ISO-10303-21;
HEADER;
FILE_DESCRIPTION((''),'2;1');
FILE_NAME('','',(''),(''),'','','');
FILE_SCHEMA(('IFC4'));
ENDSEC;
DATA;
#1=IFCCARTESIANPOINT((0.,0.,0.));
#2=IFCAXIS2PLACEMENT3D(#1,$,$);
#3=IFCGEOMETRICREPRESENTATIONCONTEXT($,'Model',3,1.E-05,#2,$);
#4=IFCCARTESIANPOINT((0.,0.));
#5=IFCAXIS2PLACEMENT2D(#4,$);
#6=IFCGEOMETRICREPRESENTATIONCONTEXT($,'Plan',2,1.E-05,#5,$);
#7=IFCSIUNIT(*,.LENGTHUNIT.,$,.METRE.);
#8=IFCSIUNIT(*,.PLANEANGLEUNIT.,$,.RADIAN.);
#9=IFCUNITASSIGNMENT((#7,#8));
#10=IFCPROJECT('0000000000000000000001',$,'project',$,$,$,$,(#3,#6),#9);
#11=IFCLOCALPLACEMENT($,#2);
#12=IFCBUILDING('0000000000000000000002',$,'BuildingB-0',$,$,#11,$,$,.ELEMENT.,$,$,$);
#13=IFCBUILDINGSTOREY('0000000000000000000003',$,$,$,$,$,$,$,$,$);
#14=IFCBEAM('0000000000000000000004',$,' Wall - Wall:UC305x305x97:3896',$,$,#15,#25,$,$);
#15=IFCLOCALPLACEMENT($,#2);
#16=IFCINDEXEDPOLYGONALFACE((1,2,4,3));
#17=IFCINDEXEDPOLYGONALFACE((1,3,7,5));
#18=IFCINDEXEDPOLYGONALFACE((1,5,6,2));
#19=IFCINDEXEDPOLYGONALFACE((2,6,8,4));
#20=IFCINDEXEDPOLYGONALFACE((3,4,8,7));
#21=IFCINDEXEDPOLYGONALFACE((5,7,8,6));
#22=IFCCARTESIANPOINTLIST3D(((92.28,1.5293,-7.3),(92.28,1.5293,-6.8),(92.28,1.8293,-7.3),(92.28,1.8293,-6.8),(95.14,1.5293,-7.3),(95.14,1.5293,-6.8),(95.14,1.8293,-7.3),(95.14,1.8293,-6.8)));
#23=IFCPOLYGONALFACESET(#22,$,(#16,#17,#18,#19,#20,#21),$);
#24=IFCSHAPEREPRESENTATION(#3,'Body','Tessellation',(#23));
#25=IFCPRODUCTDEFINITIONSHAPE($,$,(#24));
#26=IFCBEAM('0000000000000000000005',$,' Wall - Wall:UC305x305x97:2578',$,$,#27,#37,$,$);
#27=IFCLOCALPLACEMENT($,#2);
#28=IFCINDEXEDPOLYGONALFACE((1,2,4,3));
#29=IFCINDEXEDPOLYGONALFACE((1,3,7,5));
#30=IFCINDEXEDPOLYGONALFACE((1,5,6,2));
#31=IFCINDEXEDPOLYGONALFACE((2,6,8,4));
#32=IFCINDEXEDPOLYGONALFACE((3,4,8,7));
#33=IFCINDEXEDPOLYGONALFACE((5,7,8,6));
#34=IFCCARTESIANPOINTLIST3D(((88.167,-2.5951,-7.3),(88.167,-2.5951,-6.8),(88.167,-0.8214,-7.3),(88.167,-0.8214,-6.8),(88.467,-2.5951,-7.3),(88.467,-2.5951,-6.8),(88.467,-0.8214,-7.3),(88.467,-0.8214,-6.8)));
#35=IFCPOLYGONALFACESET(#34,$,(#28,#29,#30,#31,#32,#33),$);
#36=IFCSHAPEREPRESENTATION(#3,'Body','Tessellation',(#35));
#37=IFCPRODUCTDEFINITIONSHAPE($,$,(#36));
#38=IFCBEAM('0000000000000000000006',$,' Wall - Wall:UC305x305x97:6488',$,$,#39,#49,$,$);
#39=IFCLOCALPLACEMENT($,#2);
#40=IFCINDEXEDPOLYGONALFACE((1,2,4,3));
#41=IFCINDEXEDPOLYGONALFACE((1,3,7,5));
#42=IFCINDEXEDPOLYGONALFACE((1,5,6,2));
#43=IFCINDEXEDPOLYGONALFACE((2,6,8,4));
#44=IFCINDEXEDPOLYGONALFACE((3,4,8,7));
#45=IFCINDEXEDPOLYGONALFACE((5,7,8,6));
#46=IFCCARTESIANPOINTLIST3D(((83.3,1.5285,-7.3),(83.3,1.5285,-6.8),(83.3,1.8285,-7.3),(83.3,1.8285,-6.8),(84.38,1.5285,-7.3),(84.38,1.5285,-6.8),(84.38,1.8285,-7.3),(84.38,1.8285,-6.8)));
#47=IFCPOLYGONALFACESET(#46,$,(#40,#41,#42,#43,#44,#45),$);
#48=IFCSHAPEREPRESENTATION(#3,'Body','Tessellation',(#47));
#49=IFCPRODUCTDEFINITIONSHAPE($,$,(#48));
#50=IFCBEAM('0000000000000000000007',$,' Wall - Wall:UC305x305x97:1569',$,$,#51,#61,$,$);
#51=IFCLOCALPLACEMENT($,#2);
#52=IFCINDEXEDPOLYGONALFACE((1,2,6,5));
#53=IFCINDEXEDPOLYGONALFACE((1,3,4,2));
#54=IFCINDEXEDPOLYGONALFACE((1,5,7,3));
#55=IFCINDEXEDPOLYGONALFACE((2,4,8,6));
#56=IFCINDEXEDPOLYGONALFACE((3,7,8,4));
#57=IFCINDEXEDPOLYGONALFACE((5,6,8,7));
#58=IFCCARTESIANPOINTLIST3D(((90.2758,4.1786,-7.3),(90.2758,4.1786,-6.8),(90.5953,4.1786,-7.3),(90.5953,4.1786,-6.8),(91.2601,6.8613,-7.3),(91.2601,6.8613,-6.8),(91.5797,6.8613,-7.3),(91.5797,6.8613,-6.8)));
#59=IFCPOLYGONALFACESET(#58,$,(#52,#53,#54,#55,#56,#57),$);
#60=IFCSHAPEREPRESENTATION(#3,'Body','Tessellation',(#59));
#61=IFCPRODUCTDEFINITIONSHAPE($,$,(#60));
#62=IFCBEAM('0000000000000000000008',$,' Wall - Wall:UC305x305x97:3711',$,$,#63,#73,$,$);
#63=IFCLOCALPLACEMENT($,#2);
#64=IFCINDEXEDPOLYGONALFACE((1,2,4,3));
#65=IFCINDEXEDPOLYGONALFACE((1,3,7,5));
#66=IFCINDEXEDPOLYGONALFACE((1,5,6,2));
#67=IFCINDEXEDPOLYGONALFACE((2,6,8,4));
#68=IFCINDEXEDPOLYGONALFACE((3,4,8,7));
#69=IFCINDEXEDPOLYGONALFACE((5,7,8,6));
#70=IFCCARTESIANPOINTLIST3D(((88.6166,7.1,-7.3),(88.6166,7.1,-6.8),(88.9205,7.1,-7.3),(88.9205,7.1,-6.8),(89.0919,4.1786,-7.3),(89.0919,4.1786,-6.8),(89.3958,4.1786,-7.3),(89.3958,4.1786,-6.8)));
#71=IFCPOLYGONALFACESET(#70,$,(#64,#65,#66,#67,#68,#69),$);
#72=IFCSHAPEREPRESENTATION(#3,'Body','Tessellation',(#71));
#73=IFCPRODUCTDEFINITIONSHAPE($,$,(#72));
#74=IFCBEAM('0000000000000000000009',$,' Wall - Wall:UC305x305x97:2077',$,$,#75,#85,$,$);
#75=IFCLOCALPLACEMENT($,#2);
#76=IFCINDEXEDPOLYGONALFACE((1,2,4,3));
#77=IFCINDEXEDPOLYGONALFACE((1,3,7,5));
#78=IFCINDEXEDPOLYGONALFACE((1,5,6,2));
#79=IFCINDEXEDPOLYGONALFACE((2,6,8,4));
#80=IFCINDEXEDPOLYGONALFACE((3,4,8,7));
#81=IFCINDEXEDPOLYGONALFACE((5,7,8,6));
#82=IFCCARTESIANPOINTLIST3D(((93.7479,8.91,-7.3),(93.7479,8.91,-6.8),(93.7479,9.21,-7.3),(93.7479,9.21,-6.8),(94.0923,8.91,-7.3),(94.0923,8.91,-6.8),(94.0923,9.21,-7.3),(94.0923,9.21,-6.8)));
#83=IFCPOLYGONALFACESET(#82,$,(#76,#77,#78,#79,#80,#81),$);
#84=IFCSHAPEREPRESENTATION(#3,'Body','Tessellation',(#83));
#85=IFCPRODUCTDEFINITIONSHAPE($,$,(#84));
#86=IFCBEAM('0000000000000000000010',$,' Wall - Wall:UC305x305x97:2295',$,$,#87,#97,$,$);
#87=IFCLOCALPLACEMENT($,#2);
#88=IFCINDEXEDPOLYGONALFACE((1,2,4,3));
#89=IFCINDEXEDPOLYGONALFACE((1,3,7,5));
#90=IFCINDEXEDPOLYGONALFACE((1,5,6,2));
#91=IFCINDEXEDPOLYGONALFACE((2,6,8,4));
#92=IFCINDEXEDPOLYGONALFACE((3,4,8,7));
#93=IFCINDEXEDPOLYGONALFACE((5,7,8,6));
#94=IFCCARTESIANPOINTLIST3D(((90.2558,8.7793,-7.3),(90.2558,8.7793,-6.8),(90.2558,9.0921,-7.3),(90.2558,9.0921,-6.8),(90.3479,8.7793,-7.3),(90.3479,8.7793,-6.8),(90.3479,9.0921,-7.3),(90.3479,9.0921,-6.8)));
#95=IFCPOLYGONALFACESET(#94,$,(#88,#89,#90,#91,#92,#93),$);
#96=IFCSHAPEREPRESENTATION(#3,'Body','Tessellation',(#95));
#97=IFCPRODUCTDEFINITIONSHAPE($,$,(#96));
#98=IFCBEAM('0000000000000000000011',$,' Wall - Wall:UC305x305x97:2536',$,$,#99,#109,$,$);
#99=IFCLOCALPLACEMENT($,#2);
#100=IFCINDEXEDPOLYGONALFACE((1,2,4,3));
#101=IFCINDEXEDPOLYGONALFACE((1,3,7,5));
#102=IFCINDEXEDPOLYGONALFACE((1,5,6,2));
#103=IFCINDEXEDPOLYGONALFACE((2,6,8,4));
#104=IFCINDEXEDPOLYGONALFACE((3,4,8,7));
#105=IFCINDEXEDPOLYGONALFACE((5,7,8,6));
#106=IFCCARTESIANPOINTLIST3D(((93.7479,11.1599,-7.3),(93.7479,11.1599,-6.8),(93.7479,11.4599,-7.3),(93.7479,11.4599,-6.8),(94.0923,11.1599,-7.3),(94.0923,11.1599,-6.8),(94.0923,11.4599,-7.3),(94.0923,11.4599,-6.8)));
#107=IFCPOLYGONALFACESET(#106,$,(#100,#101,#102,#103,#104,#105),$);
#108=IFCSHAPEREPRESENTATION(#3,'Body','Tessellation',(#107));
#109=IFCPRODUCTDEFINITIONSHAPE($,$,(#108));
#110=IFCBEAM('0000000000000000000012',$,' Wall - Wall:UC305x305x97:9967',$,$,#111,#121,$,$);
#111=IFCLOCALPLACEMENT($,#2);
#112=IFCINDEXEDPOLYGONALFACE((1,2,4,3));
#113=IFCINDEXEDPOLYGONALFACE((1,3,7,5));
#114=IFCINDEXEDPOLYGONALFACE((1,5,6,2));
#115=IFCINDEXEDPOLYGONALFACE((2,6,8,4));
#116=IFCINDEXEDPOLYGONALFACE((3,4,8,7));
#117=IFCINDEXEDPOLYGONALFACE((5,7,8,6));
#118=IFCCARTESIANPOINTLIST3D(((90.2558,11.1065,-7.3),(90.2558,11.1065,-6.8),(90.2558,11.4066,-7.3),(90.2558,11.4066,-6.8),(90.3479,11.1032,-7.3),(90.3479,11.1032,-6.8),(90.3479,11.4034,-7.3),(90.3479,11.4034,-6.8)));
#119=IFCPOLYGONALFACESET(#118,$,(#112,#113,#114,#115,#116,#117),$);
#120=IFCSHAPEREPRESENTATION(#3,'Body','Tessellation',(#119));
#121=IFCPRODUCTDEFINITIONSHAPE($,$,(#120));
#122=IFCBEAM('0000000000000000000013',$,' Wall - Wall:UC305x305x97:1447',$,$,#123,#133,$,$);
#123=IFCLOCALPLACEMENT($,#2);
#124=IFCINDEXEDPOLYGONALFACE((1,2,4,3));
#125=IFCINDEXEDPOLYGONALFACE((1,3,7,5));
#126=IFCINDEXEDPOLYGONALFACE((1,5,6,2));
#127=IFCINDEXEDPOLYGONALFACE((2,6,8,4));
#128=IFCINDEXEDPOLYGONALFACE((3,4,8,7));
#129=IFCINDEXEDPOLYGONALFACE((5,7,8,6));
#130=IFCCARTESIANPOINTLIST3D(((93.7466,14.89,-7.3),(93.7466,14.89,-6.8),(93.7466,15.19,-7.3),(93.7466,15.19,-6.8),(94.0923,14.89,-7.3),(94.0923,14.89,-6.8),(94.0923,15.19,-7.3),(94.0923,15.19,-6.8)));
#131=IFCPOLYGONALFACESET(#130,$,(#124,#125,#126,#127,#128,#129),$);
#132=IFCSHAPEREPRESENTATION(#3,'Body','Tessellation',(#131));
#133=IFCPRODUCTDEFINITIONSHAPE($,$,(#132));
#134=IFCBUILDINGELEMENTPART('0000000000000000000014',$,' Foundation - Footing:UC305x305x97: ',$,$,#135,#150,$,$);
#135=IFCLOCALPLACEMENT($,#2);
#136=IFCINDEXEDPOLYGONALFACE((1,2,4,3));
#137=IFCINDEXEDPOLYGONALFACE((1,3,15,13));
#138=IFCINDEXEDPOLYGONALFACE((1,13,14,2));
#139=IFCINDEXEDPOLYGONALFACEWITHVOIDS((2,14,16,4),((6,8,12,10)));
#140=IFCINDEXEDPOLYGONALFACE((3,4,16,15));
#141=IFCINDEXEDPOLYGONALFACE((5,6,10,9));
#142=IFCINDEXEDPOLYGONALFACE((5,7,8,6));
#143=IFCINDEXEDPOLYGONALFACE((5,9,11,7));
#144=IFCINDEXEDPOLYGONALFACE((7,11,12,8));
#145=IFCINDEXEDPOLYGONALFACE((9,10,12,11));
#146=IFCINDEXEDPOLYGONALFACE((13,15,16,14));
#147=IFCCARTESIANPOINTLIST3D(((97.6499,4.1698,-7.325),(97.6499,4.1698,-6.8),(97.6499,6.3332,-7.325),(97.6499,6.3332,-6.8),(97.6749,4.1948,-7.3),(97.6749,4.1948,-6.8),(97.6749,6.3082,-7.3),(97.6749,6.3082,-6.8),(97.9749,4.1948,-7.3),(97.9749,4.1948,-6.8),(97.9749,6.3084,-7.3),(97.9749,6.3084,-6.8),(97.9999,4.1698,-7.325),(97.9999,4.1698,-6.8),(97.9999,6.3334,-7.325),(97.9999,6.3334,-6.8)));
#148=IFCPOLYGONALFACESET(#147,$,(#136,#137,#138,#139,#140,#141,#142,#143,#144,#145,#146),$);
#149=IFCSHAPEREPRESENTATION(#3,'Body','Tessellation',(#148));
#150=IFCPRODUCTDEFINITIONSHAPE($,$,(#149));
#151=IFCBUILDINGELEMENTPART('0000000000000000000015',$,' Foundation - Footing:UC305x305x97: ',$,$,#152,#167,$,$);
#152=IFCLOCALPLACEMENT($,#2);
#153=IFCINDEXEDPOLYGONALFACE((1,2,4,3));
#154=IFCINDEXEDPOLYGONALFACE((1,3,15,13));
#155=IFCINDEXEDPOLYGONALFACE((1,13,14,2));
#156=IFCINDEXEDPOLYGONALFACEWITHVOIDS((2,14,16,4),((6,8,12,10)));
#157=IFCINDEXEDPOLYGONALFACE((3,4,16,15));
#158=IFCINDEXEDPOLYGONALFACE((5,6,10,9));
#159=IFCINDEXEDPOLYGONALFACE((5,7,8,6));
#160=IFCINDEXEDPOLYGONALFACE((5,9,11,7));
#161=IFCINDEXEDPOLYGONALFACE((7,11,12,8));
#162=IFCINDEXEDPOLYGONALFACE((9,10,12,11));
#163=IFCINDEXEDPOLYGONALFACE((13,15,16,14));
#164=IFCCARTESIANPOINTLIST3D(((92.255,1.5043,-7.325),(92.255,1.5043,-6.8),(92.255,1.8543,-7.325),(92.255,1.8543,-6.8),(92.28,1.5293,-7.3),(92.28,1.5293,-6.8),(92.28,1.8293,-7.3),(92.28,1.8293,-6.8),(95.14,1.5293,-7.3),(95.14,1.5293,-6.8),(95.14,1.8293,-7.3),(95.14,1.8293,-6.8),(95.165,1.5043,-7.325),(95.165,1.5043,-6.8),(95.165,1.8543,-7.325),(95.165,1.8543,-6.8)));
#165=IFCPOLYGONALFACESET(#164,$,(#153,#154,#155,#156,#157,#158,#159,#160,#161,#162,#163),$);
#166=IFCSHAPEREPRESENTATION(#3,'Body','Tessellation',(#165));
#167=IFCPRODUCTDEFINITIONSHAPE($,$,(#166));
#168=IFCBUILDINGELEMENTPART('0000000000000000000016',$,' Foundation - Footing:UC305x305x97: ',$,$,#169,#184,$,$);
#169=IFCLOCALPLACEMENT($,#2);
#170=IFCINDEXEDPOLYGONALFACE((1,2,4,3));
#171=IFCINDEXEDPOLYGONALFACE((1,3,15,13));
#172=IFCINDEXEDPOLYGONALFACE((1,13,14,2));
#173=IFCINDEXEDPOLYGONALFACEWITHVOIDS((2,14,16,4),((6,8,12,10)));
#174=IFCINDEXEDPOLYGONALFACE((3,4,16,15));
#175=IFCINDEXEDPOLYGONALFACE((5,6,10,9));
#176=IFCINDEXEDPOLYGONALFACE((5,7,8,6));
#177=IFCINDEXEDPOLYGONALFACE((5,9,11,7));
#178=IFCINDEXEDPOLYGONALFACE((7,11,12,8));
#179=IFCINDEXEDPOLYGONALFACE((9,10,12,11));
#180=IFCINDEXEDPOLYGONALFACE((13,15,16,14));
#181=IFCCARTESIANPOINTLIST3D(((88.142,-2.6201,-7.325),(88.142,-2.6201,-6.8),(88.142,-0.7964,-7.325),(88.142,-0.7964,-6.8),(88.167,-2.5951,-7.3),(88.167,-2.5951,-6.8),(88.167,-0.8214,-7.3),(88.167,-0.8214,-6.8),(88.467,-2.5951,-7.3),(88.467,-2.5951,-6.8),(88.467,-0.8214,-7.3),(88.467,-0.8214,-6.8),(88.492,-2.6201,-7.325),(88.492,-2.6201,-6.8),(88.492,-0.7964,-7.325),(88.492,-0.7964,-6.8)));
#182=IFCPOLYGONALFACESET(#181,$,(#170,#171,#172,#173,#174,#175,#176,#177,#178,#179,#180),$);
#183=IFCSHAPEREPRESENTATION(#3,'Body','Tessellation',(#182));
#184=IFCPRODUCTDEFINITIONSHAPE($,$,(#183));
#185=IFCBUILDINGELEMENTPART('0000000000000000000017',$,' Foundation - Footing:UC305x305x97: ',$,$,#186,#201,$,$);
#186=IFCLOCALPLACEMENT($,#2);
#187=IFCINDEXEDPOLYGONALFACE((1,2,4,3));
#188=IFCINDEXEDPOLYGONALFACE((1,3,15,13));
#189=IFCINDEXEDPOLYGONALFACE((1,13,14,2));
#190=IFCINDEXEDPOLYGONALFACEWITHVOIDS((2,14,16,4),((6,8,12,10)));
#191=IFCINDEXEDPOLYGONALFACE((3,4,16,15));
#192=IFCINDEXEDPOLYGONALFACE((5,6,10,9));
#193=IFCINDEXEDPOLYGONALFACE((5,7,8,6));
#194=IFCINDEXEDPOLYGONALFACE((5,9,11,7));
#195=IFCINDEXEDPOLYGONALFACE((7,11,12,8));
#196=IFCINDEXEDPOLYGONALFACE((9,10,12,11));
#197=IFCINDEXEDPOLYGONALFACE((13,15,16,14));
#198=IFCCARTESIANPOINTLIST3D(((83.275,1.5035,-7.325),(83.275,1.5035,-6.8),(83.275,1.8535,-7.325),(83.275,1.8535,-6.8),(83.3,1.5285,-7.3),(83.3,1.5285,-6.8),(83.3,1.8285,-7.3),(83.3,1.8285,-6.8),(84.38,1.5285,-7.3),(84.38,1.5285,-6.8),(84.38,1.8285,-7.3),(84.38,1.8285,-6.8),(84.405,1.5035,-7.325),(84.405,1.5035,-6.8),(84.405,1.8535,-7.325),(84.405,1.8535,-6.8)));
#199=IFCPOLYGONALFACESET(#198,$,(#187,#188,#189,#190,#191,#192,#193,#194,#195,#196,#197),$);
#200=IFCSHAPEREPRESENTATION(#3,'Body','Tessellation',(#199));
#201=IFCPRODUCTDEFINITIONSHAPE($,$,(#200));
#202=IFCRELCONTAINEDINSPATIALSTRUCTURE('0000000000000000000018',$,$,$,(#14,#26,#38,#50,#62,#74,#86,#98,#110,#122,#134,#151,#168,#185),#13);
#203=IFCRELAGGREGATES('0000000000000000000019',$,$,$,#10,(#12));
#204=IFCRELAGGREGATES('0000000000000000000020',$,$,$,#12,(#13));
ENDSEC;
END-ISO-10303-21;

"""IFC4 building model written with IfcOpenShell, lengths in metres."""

from ifc_helpers import new_model, si_unit, origin, origin_2d, place, context, project, spatial, polyline, outline, extrude, element, save


model = new_model("IFC4")

# Units and contexts
model_context = context("Model", 3, precision=1e-05, world=origin())
plan_context = context("Plan", 2, precision=1e-05, world=origin_2d())
ifc_project = project(units=[si_unit("LENGTHUNIT", "METRE"), si_unit("PLANEANGLEUNIT", "RADIAN")], contexts=[model_context, plan_context])

# Building, storey
building_placement = place(None, origin())
building = spatial("IfcBuilding", under=ifc_project, at=building_placement, Name="BuildingB-0", CompositionType="ELEMENT")
storey = spatial("IfcBuildingStorey", under=building)

# Beams
element("IfcBeam", 1, inside=storey, Name=" Wall - Wall:UC305x305x97:3896", context=model_context, shape_type="SweptSolid", body=[
    extrude(outline(polyline([(95.14, 1.5293, -7.3), (95.14, 1.8293, -7.3), (92.28, 1.8293, -7.3), (92.28, 1.5293, -7.3), (95.14, 1.5293, -7.3)])), None, (0.0, 0.0, 1.0), 0.5),
])
element("IfcBeam", 2, inside=storey, Name=" Wall - Wall:UC305x305x97:2578", context=model_context, shape_type="SweptSolid", body=[
    extrude(outline(polyline([(88.467, -2.5951, -7.3), (88.467, -0.8214, -7.3), (88.167, -0.8214, -7.3), (88.167, -2.5951, -7.3), (88.467, -2.5951, -7.3)])), None, (0.0, 0.0, 1.0), 0.5),
])
element("IfcBeam", 3, inside=storey, Name=" Wall - Wall:UC305x305x97:6488", context=model_context, shape_type="SweptSolid", body=[
    extrude(outline(polyline([(84.38, 1.5285, -7.3), (84.38, 1.8285, -7.3), (83.3, 1.8285, -7.3), (83.3, 1.5285, -7.3), (84.38, 1.5285, -7.3)])), None, (0.0, 0.0, 1.0), 0.5),
])
element("IfcBeam", 4, inside=storey, Name=" Wall - Wall:UC305x305x97:1569", context=model_context, shape_type="SweptSolid", body=[
    extrude(outline(polyline([(90.5953, 4.1786, -7.3), (90.2758, 4.1786, -7.3), (91.2601, 6.8613, -7.3), (91.5797, 6.8613, -7.3), (90.5953, 4.1786, -7.3)])), None, (0.0, 0.0, 1.0), 0.5),
])
element("IfcBeam", 5, inside=storey, Name=" Wall - Wall:UC305x305x97:3711", context=model_context, shape_type="SweptSolid", body=[
    extrude(outline(polyline([(89.3958, 4.1786, -7.3), (89.0919, 4.1786, -7.3), (88.6166, 7.1, -7.3), (88.9205, 7.1, -7.3), (89.3958, 4.1786, -7.3)])), None, (0.0, 0.0, 1.0), 0.5),
])
element("IfcBeam", 6, inside=storey, Name=" Wall - Wall:UC305x305x97:2077", context=model_context, shape_type="SweptSolid", body=[
    extrude(outline(polyline([(94.0923, 8.91, -7.3), (94.0923, 9.21, -7.3), (93.7479, 9.21, -7.3), (93.7479, 8.91, -7.3), (94.0923, 8.91, -7.3)])), None, (0.0, 0.0, 1.0), 0.5),
])
element("IfcBeam", 7, inside=storey, Name=" Wall - Wall:UC305x305x97:2295", context=model_context, shape_type="SweptSolid", body=[
    extrude(outline(polyline([(90.3479, 8.7793, -7.3), (90.2558, 8.7793, -7.3), (90.2558, 9.0921, -7.3), (90.3479, 9.0921, -7.3), (90.3479, 8.7793, -7.3)])), None, (0.0, 0.0, 1.0), 0.5),
])
element("IfcBeam", 8, inside=storey, Name=" Wall - Wall:UC305x305x97:2536", context=model_context, shape_type="SweptSolid", body=[
    extrude(outline(polyline([(94.0923, 11.1599, -7.3), (93.7479, 11.1599, -7.3), (93.7479, 11.4599, -7.3), (94.0923, 11.4599, -7.3), (94.0923, 11.1599, -7.3)])), None, (0.0, 0.0, 1.0), 0.5),
])
element("IfcBeam", 9, inside=storey, Name=" Wall - Wall:UC305x305x97:9967", context=model_context, shape_type="SweptSolid", body=[
    extrude(outline(polyline([(90.3479, 11.1032, -7.3), (90.2558, 11.1065, -7.3), (90.2558, 11.4066, -7.3), (90.3479, 11.4034, -7.3), (90.3479, 11.1032, -7.3)])), None, (0.0, 0.0, 1.0), 0.5),
])
element("IfcBeam", 10, inside=storey, Name=" Wall - Wall:UC305x305x97:1447", context=model_context, shape_type="SweptSolid", body=[
    extrude(outline(polyline([(94.0923, 15.19, -7.3), (93.7466, 15.19, -7.3), (93.7466, 14.89, -7.3), (94.0923, 14.89, -7.3), (94.0923, 15.19, -7.3)])), None, (0.0, 0.0, 1.0), 0.5),
])

# Building element parts, openings
building_element_part_1 = element("IfcBuildingElementPart", 11, inside=storey, Name=" Foundation - Footing:UC305x305x97: ", context=model_context, shape_type="SweptSolid", body=[
    extrude(outline(polyline([(97.9999, 4.1698, -7.325), (97.9999, 6.3334, -7.325), (97.6499, 6.3332, -7.325), (97.6499, 4.1698, -7.325), (97.9999, 4.1698, -7.325)])), None, (0.0, 0.0, 1.0), 0.525),
])
element("IfcOpeningElement", 12, inside=storey, cuts=building_element_part_1, context=model_context, shape_type="SweptSolid", body=[
    extrude(outline(polyline([(97.9749, 4.1948, -7.3), (97.9749, 6.3084, -7.3), (97.6749, 6.3082, -7.3), (97.6749, 4.1948, -7.3), (97.9749, 4.1948, -7.3)])), None, (0.0, 0.0, 1.0), 0.5),
])
building_element_part_2 = element("IfcBuildingElementPart", 13, inside=storey, Name=" Foundation - Footing:UC305x305x97: ", context=model_context, shape_type="SweptSolid", body=[
    extrude(outline(polyline([(95.165, 1.5043, -7.325), (95.165, 1.8543, -7.325), (92.255, 1.8543, -7.325), (92.255, 1.5043, -7.325), (95.165, 1.5043, -7.325)])), None, (0.0, 0.0, 1.0), 0.525),
])
element("IfcOpeningElement", 14, inside=storey, cuts=building_element_part_2, context=model_context, shape_type="SweptSolid", body=[
    extrude(outline(polyline([(95.14, 1.5293, -7.3), (95.14, 1.8293, -7.3), (92.28, 1.8293, -7.3), (92.28, 1.5293, -7.3), (95.14, 1.5293, -7.3)])), None, (0.0, 0.0, 1.0), 0.5),
])
building_element_part_3 = element("IfcBuildingElementPart", 15, inside=storey, Name=" Foundation - Footing:UC305x305x97: ", context=model_context, shape_type="SweptSolid", body=[
    extrude(outline(polyline([(88.492, -2.6201, -7.325), (88.492, -0.7964, -7.325), (88.142, -0.7964, -7.325), (88.142, -2.6201, -7.325), (88.492, -2.6201, -7.325)])), None, (0.0, 0.0, 1.0), 0.525),
])
element("IfcOpeningElement", 16, inside=storey, cuts=building_element_part_3, context=model_context, shape_type="SweptSolid", body=[
    extrude(outline(polyline([(88.467, -2.5951, -7.3), (88.467, -0.8214, -7.3), (88.167, -0.8214, -7.3), (88.167, -2.5951, -7.3), (88.467, -2.5951, -7.3)])), None, (0.0, 0.0, 1.0), 0.5),
])
building_element_part_4 = element("IfcBuildingElementPart", 17, inside=storey, Name=" Foundation - Footing:UC305x305x97: ", context=model_context, shape_type="SweptSolid", body=[
    extrude(outline(polyline([(84.405, 1.5035, -7.325), (84.405, 1.8535, -7.325), (83.275, 1.8535, -7.325), (83.275, 1.5035, -7.325), (84.405, 1.5035, -7.325)])), None, (0.0, 0.0, 1.0), 0.525),
])
element("IfcOpeningElement", 18, inside=storey, cuts=building_element_part_4, context=model_context, shape_type="SweptSolid", body=[
    extrude(outline(polyline([(84.38, 1.5285, -7.3), (84.38, 1.8285, -7.3), (83.3, 1.8285, -7.3), (83.3, 1.5285, -7.3), (84.38, 1.5285, -7.3)])), None, (0.0, 0.0, 1.0), 0.5),
])

save(model, "model.ifc")
